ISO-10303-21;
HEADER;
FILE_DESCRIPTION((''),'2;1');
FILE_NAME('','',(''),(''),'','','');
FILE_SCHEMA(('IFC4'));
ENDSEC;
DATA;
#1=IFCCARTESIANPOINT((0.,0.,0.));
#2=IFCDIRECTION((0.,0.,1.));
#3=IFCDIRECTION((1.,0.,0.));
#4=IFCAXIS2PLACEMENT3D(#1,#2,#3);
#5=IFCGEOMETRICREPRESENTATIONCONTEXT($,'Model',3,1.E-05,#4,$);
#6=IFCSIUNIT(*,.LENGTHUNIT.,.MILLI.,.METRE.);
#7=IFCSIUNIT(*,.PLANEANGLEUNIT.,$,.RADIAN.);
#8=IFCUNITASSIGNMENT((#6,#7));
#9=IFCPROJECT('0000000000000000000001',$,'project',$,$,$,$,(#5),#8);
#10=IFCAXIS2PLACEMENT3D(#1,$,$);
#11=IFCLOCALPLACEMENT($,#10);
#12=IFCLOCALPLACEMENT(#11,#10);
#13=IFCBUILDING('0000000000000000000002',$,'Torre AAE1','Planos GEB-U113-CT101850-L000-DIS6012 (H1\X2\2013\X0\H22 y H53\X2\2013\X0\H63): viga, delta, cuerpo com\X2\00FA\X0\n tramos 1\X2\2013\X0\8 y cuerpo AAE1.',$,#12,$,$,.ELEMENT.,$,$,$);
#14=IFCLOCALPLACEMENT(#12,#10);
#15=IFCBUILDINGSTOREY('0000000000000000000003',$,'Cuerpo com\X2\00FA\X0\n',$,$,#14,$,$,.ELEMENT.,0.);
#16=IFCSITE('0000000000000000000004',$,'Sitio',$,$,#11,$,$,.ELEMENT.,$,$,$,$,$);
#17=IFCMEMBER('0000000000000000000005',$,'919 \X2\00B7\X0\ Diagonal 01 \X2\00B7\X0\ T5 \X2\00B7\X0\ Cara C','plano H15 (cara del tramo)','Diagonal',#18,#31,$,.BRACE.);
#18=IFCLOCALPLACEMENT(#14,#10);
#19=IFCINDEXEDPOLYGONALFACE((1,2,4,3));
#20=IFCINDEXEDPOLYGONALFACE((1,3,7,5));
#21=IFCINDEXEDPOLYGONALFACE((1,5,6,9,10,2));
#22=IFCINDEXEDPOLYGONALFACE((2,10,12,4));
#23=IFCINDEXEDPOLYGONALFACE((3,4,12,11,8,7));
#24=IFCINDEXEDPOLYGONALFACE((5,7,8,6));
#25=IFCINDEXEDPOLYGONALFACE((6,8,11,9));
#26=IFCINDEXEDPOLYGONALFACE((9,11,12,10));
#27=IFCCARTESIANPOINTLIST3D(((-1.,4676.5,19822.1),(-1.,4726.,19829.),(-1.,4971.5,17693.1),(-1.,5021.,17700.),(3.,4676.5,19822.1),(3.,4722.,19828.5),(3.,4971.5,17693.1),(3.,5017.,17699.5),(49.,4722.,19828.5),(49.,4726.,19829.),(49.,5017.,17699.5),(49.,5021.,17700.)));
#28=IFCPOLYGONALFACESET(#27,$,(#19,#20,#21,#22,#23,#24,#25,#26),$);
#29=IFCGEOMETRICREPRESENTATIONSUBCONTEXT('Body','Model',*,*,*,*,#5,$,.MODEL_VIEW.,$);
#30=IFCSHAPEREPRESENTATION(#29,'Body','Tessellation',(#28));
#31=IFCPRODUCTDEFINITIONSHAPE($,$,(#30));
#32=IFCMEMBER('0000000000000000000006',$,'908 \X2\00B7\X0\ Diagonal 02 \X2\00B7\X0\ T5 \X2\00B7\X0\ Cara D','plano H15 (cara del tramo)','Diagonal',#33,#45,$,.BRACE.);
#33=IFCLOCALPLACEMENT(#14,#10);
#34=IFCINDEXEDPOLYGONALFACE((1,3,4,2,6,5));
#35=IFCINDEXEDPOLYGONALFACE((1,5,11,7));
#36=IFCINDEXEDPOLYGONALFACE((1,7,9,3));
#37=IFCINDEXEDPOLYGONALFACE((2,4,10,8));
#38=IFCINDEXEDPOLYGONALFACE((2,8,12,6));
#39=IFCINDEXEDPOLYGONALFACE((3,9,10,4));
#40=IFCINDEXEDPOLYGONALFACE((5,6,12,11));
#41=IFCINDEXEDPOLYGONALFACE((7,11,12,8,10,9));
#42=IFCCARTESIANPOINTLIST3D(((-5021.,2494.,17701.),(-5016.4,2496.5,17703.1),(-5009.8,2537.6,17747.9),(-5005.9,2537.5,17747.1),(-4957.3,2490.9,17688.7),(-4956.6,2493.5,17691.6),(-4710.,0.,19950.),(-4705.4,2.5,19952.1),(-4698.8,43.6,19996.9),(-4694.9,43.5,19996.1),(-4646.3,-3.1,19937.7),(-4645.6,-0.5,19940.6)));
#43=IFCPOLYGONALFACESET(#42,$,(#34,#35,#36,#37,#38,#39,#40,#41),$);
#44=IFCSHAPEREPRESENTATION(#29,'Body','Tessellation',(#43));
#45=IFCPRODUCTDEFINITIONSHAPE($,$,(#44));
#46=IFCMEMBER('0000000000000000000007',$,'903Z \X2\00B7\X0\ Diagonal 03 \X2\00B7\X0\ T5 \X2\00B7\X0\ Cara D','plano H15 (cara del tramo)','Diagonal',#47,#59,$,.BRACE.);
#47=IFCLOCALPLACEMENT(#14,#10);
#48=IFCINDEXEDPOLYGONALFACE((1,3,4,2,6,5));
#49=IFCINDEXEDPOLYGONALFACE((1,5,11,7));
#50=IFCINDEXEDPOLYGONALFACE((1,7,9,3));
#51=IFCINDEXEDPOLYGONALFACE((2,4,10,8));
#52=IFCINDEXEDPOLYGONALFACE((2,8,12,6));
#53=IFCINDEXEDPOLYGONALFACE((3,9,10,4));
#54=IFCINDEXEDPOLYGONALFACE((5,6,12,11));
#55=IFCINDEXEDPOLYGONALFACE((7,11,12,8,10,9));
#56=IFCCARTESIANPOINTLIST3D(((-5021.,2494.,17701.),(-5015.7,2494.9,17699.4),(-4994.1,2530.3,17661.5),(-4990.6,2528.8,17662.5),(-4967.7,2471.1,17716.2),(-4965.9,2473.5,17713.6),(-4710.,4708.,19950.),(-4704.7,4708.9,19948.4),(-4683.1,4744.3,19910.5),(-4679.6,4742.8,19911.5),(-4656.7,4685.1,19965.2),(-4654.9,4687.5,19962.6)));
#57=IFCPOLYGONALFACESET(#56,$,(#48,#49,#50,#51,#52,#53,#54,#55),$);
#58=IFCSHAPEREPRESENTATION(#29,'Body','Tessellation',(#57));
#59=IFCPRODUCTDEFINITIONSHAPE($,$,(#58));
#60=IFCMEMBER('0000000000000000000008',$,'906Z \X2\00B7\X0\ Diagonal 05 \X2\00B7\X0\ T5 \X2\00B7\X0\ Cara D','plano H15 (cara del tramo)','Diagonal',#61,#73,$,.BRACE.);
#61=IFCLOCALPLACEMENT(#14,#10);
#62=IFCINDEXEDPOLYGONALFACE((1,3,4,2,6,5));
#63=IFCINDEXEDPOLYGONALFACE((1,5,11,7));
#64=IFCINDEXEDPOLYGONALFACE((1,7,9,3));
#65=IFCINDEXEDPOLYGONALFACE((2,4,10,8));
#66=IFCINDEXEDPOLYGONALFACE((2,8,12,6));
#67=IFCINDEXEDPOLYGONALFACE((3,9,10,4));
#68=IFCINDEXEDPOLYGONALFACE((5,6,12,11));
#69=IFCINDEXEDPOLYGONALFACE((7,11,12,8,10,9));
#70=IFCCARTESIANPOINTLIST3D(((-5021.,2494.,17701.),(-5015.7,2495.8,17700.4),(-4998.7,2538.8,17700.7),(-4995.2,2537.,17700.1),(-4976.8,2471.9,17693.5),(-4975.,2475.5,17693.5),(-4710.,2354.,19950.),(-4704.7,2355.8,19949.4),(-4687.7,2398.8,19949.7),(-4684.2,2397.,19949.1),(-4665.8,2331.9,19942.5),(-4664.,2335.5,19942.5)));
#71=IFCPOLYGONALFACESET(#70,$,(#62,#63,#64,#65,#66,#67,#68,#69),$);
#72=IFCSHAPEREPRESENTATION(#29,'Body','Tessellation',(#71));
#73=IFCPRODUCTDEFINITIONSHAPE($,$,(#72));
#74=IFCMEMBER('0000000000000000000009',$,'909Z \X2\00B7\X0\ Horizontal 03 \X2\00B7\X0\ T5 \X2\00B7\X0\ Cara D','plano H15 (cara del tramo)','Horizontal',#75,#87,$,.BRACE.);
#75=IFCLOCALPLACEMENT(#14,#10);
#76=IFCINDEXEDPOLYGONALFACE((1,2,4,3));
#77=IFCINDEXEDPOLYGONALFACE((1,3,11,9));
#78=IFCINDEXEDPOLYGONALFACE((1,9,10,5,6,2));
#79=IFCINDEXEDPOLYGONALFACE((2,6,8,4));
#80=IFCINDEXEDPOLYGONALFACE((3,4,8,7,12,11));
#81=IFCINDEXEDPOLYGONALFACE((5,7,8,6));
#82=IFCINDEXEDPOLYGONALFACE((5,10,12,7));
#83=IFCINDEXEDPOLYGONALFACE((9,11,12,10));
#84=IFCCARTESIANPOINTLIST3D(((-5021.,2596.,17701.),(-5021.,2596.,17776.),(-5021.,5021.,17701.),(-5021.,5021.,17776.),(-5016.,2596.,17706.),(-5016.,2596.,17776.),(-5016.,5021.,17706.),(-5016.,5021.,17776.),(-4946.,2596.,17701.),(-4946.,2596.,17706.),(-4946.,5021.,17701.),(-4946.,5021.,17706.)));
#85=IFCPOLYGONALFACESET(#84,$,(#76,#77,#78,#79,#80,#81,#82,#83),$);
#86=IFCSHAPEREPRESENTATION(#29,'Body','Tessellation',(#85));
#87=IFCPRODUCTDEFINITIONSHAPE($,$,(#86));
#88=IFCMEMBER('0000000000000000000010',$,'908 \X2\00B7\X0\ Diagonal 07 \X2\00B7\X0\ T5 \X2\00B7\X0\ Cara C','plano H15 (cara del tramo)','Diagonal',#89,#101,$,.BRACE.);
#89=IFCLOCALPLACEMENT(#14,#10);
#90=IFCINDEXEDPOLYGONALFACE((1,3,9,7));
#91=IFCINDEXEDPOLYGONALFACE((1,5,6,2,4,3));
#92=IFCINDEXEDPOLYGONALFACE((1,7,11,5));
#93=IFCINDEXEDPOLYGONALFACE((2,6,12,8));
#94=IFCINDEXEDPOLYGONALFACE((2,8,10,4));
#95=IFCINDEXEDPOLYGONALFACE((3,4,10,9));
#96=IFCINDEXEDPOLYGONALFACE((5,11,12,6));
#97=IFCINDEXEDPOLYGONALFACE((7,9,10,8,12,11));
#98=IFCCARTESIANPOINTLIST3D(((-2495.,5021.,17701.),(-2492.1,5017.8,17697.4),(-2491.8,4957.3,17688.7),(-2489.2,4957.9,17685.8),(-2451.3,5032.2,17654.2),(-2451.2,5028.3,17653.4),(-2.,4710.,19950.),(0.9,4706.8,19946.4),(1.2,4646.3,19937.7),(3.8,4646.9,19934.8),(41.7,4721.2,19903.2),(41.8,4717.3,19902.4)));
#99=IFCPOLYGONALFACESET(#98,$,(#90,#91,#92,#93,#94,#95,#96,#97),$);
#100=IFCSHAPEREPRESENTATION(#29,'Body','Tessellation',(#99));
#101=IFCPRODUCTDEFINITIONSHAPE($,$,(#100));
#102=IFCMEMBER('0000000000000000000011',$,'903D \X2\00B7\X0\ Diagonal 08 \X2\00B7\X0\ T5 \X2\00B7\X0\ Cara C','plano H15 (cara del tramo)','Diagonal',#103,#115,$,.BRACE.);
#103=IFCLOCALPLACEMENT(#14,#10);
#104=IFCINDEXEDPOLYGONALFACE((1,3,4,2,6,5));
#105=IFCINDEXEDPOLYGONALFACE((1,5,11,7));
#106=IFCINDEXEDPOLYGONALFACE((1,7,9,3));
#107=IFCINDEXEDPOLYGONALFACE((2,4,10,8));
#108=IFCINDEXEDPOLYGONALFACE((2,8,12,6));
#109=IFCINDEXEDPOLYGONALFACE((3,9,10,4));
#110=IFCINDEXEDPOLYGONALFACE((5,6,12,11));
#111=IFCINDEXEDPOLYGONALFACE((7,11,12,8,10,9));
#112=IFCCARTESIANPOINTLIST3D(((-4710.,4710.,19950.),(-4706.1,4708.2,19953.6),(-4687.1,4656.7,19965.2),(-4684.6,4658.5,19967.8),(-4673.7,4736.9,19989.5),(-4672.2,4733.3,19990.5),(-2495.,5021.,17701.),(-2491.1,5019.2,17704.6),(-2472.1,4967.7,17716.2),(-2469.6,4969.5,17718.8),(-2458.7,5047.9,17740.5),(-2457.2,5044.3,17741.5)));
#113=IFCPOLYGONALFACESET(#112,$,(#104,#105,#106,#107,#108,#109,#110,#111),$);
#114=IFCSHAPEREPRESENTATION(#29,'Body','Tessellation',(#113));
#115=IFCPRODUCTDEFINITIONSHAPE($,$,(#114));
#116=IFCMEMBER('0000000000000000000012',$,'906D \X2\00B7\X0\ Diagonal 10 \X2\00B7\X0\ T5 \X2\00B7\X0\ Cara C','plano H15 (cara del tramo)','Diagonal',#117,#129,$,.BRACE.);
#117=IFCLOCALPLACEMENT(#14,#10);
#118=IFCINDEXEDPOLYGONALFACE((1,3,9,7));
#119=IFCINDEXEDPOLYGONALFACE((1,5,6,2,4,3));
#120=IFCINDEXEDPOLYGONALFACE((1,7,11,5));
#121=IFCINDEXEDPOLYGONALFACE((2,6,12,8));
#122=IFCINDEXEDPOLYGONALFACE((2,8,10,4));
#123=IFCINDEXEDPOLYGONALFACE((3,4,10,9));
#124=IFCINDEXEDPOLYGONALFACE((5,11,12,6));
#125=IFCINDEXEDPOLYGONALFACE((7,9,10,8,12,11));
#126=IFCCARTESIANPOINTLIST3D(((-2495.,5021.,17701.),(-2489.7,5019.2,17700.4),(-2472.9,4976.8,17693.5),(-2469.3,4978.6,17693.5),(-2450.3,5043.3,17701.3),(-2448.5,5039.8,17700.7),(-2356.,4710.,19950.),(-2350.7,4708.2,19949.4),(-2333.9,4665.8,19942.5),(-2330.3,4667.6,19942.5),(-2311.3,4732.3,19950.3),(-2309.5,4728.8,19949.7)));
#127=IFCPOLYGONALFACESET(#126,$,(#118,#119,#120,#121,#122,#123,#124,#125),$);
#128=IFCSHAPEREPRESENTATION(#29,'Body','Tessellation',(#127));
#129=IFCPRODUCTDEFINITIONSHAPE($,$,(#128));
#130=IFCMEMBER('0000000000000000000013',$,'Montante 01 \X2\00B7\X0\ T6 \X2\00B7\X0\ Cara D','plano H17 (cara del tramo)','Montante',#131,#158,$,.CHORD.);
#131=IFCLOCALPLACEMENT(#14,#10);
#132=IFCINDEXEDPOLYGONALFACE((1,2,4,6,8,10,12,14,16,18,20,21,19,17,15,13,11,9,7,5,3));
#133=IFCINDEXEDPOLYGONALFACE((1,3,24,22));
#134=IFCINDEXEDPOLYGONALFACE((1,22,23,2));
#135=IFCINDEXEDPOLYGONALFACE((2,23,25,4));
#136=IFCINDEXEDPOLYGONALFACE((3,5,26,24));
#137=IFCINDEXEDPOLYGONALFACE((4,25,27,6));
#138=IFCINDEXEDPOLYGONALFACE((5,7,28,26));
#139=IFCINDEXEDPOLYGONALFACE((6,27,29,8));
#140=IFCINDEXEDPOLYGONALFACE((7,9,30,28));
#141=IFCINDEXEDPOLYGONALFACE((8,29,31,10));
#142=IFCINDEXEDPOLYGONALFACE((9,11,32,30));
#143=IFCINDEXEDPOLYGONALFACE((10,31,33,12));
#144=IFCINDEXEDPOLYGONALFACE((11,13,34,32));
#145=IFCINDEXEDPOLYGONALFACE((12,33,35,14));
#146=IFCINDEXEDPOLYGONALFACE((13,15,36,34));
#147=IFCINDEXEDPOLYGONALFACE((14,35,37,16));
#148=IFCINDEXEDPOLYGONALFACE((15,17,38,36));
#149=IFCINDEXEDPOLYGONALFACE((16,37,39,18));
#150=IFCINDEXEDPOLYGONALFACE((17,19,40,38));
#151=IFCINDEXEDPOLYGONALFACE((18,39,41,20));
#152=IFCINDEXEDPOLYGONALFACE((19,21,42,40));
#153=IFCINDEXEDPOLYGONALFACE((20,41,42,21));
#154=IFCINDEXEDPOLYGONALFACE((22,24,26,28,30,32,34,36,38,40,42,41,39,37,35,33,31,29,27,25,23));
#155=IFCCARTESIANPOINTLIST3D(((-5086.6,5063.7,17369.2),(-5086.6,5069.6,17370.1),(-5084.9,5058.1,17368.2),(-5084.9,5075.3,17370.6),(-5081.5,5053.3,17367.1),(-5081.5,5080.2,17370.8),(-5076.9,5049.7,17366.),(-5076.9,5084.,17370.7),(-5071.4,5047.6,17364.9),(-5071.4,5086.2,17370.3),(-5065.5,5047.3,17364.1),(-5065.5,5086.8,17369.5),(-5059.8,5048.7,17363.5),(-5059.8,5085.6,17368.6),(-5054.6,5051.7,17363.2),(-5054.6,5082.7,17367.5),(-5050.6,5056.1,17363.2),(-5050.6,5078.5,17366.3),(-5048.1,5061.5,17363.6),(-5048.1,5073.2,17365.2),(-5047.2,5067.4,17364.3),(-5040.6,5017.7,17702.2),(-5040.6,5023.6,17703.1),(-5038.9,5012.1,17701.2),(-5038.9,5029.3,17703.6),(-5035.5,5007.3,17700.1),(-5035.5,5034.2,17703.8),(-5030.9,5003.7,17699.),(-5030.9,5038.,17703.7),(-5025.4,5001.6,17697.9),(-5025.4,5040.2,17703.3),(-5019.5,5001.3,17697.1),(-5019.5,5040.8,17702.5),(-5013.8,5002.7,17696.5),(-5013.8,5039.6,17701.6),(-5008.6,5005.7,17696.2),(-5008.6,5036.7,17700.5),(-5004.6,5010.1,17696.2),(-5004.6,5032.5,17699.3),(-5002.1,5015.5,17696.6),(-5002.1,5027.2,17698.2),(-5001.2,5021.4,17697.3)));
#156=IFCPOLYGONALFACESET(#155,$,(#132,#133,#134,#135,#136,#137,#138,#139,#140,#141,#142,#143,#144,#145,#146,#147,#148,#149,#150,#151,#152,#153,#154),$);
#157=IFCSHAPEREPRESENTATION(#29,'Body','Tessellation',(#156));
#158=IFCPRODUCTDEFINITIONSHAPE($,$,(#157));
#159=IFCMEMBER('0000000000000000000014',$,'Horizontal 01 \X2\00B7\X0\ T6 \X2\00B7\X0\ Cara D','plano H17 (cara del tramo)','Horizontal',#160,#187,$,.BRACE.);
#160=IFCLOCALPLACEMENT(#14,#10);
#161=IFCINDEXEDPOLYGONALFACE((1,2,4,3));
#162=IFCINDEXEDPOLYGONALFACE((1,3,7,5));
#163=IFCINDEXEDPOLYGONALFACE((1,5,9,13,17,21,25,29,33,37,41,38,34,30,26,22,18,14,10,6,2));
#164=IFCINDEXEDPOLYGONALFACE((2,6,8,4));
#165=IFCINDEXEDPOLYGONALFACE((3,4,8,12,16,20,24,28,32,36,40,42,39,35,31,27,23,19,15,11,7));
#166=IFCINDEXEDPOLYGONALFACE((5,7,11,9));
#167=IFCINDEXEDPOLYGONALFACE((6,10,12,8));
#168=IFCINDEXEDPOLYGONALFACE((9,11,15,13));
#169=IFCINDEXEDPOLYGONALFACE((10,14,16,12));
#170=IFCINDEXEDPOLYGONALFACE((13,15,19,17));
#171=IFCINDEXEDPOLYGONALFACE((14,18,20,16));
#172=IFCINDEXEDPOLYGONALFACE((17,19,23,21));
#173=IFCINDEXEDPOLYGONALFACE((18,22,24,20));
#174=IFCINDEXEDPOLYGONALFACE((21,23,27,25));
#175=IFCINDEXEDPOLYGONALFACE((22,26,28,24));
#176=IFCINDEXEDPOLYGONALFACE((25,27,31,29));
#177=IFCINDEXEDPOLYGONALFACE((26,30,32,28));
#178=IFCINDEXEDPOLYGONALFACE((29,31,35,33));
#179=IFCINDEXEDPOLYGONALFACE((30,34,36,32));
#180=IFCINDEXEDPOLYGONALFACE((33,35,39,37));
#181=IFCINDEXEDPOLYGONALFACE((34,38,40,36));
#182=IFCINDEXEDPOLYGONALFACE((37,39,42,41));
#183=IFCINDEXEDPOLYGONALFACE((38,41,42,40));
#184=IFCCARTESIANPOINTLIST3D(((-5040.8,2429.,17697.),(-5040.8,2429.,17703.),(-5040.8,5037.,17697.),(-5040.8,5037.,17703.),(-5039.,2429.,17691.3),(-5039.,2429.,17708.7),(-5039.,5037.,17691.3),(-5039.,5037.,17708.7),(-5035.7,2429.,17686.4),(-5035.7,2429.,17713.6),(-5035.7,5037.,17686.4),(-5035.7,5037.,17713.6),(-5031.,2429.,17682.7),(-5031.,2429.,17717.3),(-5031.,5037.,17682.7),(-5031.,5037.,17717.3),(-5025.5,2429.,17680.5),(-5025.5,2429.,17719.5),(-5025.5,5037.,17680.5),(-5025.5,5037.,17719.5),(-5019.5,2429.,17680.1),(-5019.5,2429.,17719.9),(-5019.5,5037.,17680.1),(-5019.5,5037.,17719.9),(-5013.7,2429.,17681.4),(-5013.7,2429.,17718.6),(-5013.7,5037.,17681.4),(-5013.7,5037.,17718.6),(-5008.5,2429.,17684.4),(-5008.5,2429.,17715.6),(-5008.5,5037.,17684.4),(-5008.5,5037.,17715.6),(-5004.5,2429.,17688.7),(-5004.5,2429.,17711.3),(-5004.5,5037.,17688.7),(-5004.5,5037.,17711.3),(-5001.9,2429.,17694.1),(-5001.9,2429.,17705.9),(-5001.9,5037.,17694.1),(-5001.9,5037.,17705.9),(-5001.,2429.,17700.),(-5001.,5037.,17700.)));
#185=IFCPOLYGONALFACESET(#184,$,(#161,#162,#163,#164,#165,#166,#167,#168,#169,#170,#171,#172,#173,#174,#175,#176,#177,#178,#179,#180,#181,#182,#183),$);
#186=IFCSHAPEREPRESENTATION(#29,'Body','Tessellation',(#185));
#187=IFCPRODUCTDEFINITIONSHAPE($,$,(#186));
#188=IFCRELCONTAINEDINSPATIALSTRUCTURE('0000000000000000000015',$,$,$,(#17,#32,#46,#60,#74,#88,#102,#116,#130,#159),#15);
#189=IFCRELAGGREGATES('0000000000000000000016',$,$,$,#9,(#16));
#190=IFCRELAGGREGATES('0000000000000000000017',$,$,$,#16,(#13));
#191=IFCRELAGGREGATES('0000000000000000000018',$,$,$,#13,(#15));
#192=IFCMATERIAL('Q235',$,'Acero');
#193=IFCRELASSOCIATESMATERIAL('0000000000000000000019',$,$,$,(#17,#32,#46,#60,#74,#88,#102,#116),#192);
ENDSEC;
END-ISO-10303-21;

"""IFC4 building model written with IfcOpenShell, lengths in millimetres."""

from ifc_helpers import new_model, si_unit, frame, frame_2d, origin, origin_with_axes, place, context, subcontext, project, spatial, circle, l_section, extrude, material, element, save


model = new_model("IFC4")

# Units and contexts
model_context = context("Model", 3, precision=1e-05, world=origin_with_axes())
body_context = subcontext(model_context, "Body", "Model", "MODEL_VIEW")
ifc_project = project(units=[si_unit("LENGTHUNIT", "METRE", prefix="MILLI"), si_unit("PLANEANGLEUNIT", "RADIAN")], contexts=[model_context])

# Site, building, storey
site_placement = place(None, origin())
site = spatial("IfcSite", under=ifc_project, at=site_placement, Name="Sitio", CompositionType="ELEMENT")
building_placement = place(site_placement, origin())
building = spatial("IfcBuilding", under=site, at=building_placement, Name="Torre AAE1", Description="Planos GEB-U113-CT101850-L000-DIS6012 (H1–H22 y H53–H63): viga, delta, cuerpo común tramos 1–8 y cuerpo AAE1.", CompositionType="ELEMENT")
storey_placement = place(building_placement, origin())
storey = spatial("IfcBuildingStorey", under=building, at=storey_placement, Name="Cuerpo común", CompositionType="ELEMENT", Elevation=0.0)

# Members
ifc_material_1 = material(Name="Q235", Category="Acero")
member_1_placement = place(storey_placement, frame((-1.0, 5021.0, 17700.0), z_axis=(0.0, -0.137251, 0.990536), x_axis=(0.000207, -0.990536, -0.137251)))
element("IfcMember", 1, at=member_1_placement, inside=storey, material=ifc_material_1, Name="919 · Diagonal 01 · T5 · Cara C", Description="plano H15 (cara del tramo)", ObjectType="Diagonal", PredefinedType="BRACE", context=body_context, shape_type="SweptSolid", body=[
    extrude(l_section(Depth=50.0, Width=50.0, Thickness=4.0, at=frame_2d((25.0, 25.0))), None, (0.0, 0.0, 1.0), 2149.3),
])
member_2_placement = place(storey_placement, frame((-5021.0, 2494.0, 17701.0), z_axis=(0.092212, -0.739478, 0.666835), x_axis=(0.980756, -0.048288, -0.189171)))
element("IfcMember", 2, at=member_2_placement, inside=storey, material=ifc_material_1, Name="908 · Diagonal 02 · T5 · Cara D", Description="plano H15 (cara del tramo)", ObjectType="Diagonal", PredefinedType="BRACE", context=body_context, shape_type="SweptSolid", body=[
    extrude(l_section(Depth=65.0, Width=65.0, Thickness=4.0, at=frame_2d((32.5, 32.5))), None, (0.0, 0.0, 1.0), 3372.6),
])
member_3_placement = place(storey_placement, frame((-5021.0, 2494.0, 17701.0), z_axis=(0.09807, 0.698158, 0.709195), x_axis=(0.888624, -0.382258, 0.253427)))
element("IfcMember", 3, at=member_3_placement, inside=storey, material=ifc_material_1, Name="903Z · Diagonal 03 · T5 · Cara D", Description="plano H15 (cara del tramo)", ObjectType="Diagonal", PredefinedType="BRACE", context=body_context, shape_type="SweptSolid", body=[
    extrude(l_section(Depth=60.0, Width=60.0, Thickness=4.0, at=frame_2d((30.0, 30.0))), None, (0.0, 0.0, 1.0), 3171.2),
])
member_4_placement = place(storey_placement, frame((-5021.0, 2494.0, 17701.0), z_axis=(0.136721, -0.061546, 0.988696), x_axis=(0.884571, -0.44169, -0.149817)))
element("IfcMember", 4, at=member_4_placement, inside=storey, material=ifc_material_1, Name="906Z · Diagonal 05 · T5 · Cara D", Description="plano H15 (cara del tramo)", ObjectType="Diagonal", PredefinedType="BRACE", context=body_context, shape_type="SweptSolid", body=[
    extrude(l_section(Depth=50.0, Width=50.0, Thickness=4.0, at=frame_2d((25.0, 25.0))), None, (0.0, 0.0, 1.0), 2274.7),
])
member_5_placement = place(storey_placement, frame((-5021.0, 5021.0, 17701.0), z_axis=(0.0, -1.0, 0.0), x_axis=(1.0, 0.0, 0.0)))
element("IfcMember", 5, at=member_5_placement, inside=storey, material=ifc_material_1, Name="909Z · Horizontal 03 · T5 · Cara D", Description="plano H15 (cara del tramo)", ObjectType="Horizontal", PredefinedType="BRACE", context=body_context, shape_type="SweptSolid", body=[
    extrude(l_section(Depth=75.0, Width=75.0, Thickness=5.0, at=frame_2d((37.5, 37.5))), None, (0.0, 0.0, 1.0), 2425.0),
])
member_6_placement = place(storey_placement, frame((-2495.0, 5021.0, 17701.0), z_axis=(0.739344, -0.092233, 0.666981), x_axis=(0.048477, -0.980712, -0.189352)))
element("IfcMember", 6, at=member_6_placement, inside=storey, material=ifc_material_1, Name="908 · Diagonal 07 · T5 · Cara C", Description="plano H15 (cara del tramo)", ObjectType="Diagonal", PredefinedType="BRACE", context=body_context, shape_type="SweptSolid", body=[
    extrude(l_section(Depth=65.0, Width=65.0, Thickness=4.0, at=frame_2d((32.5, 32.5))), None, (0.0, 0.0, 1.0), 3371.9),
])
member_7_placement = place(storey_placement, frame((-2495.0, 5021.0, 17701.0), z_axis=(-0.69832, -0.098049, 0.709039), x_axis=(0.382229, -0.888595, 0.253573)))
element("IfcMember", 7, at=member_7_placement, inside=storey, material=ifc_material_1, Name="903D · Diagonal 08 · T5 · Cara C", Description="plano H15 (cara del tramo)", ObjectType="Diagonal", PredefinedType="BRACE", context=body_context, shape_type="SweptSolid", body=[
    extrude(l_section(Depth=60.0, Width=60.0, Thickness=4.0, at=frame_2d((30.0, 30.0))), None, (0.0, 0.0, 1.0), 3171.9),
])
member_8_placement = place(storey_placement, frame((-2495.0, 5021.0, 17701.0), z_axis=(0.061108, -0.136724, 0.988723), x_axis=(0.441979, -0.884459, -0.149623)))
element("IfcMember", 8, at=member_8_placement, inside=storey, material=ifc_material_1, Name="906D · Diagonal 10 · T5 · Cara C", Description="plano H15 (cara del tramo)", ObjectType="Diagonal", PredefinedType="BRACE", context=body_context, shape_type="SweptSolid", body=[
    extrude(l_section(Depth=50.0, Width=50.0, Thickness=4.0, at=frame_2d((25.0, 25.0))), None, (0.0, 0.0, 1.0), 2274.7),
])
member_9_placement = place(storey_placement, frame((-5021.0, 5021.0, 17700.0), z_axis=(-0.135575, 0.135575, -0.981447), x_axis=(0.990767, 0.018552, -0.1343)))
element("IfcMember", 9, at=member_9_placement, inside=storey, Name="Montante 01 · T6 · Cara D", Description="plano H17 (cara del tramo)", ObjectType="Montante", PredefinedType="CHORD", context=body_context, shape_type="SweptSolid", body=[
    extrude(circle(Radius=20.0), None, (0.0, 0.0, 1.0), 339.3),
])
for number, where, z_axis, x_axis, name in (
    (10, (-5021.0, 5037.0, 17700.0), (0.0, -1.0, 0.0), (1.0, 0.0, 0.0), "Horizontal 01 · T6 · Cara D"),
):
    element("IfcMember", number, at=place(storey_placement, frame(where, z_axis=z_axis, x_axis=x_axis)), inside=storey, Name=name, Description="plano H17 (cara del tramo)", ObjectType="Horizontal", PredefinedType="BRACE", context=body_context, shape_type="SweptSolid", body=[
        extrude(circle(Radius=20.0), None, (0.0, 0.0, 1.0), 2608.0),
    ])

save(model, "model.ifc")
